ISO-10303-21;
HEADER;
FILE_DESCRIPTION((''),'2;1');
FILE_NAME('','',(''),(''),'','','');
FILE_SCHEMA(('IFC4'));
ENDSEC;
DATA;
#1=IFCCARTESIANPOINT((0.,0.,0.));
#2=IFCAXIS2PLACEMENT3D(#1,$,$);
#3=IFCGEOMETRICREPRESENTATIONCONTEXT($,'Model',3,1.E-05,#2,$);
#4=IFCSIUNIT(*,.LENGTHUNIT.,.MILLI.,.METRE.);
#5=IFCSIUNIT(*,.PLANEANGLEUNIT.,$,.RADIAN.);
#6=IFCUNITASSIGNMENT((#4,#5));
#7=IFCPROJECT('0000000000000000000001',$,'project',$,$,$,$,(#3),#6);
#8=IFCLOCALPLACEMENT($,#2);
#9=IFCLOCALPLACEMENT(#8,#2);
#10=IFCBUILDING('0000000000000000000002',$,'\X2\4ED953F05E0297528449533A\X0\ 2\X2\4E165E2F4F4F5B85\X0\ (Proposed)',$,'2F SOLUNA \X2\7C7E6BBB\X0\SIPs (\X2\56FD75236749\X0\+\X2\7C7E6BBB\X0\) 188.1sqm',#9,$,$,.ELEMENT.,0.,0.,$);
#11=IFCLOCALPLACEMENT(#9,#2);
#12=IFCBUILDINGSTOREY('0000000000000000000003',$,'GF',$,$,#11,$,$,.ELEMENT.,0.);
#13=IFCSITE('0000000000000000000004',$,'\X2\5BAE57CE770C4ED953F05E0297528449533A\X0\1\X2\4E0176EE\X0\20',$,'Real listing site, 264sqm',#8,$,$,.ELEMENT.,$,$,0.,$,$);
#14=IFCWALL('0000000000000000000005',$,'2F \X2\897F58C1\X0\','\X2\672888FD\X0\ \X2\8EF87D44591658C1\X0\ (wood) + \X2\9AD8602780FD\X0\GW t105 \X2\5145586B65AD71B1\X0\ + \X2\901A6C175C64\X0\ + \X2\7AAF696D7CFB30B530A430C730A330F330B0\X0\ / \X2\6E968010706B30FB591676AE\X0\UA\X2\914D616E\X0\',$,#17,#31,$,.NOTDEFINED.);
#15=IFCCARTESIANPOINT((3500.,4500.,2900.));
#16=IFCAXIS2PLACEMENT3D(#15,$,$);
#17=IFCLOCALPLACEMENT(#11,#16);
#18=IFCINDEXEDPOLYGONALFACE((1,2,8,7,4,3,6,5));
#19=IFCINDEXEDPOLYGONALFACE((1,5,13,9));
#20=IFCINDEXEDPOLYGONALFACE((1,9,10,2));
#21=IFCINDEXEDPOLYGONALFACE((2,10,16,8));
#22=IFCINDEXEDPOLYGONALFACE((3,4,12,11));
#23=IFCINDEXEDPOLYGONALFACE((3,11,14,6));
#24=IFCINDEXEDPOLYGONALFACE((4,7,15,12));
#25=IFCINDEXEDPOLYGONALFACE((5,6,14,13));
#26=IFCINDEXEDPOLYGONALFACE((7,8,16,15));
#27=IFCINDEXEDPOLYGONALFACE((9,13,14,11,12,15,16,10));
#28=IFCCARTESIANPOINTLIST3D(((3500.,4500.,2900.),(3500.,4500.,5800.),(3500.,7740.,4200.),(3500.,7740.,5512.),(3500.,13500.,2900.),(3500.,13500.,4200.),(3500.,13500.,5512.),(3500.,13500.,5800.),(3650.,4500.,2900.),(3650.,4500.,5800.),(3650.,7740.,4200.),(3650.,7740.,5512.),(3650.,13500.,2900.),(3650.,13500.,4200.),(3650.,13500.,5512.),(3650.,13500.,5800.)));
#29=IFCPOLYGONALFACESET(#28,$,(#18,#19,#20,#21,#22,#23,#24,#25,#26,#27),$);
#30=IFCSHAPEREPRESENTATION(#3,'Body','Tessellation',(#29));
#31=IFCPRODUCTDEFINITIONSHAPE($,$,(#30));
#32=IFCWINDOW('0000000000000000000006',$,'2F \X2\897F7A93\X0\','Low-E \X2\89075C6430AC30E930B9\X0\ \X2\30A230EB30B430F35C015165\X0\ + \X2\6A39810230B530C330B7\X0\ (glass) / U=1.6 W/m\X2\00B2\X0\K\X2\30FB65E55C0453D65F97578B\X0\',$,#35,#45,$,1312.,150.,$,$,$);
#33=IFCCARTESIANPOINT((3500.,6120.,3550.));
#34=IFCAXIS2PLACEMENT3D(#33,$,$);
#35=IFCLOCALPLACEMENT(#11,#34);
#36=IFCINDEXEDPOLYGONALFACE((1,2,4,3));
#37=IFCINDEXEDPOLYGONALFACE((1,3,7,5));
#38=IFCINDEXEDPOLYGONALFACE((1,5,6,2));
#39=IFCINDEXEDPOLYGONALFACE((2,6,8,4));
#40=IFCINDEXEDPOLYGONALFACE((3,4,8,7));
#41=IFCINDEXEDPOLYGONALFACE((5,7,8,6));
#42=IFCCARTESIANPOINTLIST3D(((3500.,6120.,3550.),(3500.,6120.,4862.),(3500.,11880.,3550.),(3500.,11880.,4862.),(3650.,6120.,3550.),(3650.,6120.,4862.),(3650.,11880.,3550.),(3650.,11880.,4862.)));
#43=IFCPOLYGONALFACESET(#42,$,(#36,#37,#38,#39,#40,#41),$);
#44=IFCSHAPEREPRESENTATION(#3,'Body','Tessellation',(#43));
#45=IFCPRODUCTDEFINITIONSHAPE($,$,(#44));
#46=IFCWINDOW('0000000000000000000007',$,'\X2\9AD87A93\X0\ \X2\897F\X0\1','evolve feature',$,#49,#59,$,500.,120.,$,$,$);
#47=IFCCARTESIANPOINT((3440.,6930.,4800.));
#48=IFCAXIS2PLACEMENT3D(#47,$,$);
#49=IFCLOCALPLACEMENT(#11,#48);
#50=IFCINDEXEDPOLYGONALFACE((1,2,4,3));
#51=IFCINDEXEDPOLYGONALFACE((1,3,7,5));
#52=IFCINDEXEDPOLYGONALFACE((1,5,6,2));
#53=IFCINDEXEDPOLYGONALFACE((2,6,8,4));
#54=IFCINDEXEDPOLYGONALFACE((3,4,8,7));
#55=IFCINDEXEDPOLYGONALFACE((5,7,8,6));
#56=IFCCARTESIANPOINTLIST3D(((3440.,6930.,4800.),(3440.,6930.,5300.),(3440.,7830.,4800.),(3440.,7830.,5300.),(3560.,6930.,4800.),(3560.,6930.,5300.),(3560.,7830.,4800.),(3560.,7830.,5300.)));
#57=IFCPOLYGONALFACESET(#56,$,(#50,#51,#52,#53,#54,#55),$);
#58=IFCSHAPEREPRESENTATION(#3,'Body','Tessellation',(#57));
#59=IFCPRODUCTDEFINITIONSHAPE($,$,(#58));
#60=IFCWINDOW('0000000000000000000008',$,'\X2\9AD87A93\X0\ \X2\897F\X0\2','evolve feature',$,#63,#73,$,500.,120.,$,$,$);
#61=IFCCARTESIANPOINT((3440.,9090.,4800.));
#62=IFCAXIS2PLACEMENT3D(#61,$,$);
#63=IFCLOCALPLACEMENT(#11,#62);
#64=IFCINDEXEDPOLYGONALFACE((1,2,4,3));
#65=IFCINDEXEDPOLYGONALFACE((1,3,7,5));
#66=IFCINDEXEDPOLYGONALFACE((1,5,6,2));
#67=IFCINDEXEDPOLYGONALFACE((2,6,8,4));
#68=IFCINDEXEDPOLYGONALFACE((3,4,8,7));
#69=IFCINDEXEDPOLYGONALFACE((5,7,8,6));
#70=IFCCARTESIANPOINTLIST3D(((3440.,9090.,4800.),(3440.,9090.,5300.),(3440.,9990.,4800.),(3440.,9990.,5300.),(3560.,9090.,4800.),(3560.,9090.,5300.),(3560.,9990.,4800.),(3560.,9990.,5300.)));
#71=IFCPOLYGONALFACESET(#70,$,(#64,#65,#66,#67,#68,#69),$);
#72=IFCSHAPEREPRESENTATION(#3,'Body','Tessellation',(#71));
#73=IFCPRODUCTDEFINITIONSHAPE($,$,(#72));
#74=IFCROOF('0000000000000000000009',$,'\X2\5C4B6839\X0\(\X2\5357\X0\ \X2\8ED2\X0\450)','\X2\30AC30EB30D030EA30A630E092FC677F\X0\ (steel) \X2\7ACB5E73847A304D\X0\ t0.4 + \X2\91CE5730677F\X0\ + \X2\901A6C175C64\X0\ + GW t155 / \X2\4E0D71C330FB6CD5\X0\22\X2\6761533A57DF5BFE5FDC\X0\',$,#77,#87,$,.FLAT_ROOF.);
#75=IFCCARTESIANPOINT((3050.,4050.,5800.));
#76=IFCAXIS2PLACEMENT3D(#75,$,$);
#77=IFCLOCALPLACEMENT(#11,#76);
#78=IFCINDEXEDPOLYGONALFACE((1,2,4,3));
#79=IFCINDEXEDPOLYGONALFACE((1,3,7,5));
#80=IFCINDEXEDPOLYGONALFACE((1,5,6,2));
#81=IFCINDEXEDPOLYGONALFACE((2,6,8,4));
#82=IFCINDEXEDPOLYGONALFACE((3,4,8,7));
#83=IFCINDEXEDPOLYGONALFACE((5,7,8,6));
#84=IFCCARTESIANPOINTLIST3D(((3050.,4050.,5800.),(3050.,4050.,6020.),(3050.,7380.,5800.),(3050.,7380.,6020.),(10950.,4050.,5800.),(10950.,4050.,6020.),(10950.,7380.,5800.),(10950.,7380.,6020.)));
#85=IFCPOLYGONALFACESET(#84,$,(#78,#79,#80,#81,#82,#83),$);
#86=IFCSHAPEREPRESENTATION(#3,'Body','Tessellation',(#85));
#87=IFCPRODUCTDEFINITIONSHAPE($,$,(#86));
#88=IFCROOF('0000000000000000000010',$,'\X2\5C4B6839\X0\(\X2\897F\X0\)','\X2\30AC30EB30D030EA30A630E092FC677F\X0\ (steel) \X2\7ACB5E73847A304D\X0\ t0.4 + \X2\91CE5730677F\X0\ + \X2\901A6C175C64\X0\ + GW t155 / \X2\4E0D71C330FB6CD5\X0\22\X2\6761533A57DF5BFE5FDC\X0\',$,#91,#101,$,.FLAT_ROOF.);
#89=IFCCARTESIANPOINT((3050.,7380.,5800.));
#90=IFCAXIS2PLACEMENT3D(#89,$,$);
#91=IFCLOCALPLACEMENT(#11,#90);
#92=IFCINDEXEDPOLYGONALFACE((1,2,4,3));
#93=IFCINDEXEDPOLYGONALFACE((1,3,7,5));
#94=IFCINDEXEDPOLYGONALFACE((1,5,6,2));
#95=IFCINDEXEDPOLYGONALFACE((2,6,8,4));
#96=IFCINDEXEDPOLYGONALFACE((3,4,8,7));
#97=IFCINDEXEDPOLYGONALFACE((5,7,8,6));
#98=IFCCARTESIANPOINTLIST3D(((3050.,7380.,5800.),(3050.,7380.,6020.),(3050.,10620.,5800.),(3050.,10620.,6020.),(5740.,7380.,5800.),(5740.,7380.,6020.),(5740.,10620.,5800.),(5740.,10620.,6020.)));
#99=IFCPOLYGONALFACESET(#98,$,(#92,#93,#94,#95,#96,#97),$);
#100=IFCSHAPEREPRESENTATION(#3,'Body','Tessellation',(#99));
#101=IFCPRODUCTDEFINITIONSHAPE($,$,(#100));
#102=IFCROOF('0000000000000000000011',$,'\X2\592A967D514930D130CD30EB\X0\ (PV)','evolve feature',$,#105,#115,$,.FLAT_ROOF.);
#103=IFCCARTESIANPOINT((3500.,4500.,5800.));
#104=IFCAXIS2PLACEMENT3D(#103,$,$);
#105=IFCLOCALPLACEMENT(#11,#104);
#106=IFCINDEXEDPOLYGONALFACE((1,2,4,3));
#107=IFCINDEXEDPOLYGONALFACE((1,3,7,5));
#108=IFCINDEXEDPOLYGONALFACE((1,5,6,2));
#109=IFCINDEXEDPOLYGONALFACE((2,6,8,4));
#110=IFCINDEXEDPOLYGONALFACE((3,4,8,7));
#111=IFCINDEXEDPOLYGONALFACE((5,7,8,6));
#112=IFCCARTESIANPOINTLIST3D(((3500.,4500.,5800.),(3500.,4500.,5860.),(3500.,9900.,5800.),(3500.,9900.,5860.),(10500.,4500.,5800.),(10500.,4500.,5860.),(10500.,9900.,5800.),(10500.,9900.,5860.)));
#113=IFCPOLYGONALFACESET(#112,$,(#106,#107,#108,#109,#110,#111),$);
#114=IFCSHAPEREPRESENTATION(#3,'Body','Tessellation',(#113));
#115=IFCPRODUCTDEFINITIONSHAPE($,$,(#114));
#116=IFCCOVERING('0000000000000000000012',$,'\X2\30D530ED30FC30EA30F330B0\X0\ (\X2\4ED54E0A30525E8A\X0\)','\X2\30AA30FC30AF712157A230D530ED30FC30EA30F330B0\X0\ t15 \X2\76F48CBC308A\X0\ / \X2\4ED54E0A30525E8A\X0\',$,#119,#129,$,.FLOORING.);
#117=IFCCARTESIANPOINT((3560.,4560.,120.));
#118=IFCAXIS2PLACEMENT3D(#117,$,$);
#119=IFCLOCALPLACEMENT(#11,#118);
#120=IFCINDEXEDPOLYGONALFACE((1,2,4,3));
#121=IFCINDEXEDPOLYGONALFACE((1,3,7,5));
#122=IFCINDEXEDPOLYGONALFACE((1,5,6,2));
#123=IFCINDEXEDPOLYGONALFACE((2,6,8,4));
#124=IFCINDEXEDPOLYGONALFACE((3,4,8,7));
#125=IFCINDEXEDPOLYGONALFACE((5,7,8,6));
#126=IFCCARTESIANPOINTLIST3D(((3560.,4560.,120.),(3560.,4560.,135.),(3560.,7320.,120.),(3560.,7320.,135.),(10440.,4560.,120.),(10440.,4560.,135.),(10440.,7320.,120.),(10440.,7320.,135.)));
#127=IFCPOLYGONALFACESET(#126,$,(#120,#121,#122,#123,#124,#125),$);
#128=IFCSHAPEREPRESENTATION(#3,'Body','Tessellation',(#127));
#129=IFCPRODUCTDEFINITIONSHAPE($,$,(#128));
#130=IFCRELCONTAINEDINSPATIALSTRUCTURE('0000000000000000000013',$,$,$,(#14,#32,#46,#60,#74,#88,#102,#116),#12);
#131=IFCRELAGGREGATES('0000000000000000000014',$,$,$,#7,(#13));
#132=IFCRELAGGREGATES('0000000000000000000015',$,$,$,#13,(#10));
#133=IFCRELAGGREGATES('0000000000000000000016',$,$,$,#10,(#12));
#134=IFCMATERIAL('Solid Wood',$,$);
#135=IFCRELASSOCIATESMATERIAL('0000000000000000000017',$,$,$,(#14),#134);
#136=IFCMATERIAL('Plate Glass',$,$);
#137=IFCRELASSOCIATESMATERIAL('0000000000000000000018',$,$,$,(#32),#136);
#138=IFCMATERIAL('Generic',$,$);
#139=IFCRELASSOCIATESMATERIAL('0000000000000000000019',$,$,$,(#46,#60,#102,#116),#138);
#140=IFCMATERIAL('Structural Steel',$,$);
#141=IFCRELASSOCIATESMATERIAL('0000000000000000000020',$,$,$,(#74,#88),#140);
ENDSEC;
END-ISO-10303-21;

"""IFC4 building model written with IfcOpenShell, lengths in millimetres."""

from ifc_helpers import new_model, si_unit, frame, frame_2d, origin, place, context, project, spatial, rectangle, extrude, material, element, fill, save


model = new_model("IFC4")

# Units and contexts
model_context = context("Model", 3, precision=1e-05, world=origin())
ifc_project = project(units=[si_unit("LENGTHUNIT", "METRE", prefix="MILLI"), si_unit("PLANEANGLEUNIT", "RADIAN")], contexts=[model_context])

# Site, building, storey
site_placement = place(None, origin())
site = spatial("IfcSite", under=ifc_project, at=site_placement, Name="宮城県仙台市青葉区1丁目20", ObjectType="Real listing site, 264sqm", CompositionType="ELEMENT", RefElevation=0.0)
building_placement = place(site_placement, origin())
building = spatial("IfcBuilding", under=site, at=building_placement, Name="仙台市青葉区 2世帯住宅 (Proposed)", ObjectType="2F SOLUNA 籾殻SIPs (国産杉+籾殻) 188.1sqm", CompositionType="ELEMENT", ElevationOfRefHeight=0.0, ElevationOfTerrain=0.0)
storey_placement = place(building_placement, origin())
storey = spatial("IfcBuildingStorey", under=building, at=storey_placement, Name="GF", CompositionType="ELEMENT", Elevation=0.0)

# Shared definitions
ifc_material_1 = material(Name="Solid Wood")
ifc_material_2 = material(Name="Generic")

# Shared definitions
ifc_material_3 = material(Name="Plate Glass")

# Wall, openings, windows
wall_1_placement = place(storey_placement, frame((3500.0, 4500.0, 2900.0)))
wall_1 = element("IfcWall", 1, at=wall_1_placement, inside=storey, material=ifc_material_1, Name="2F 西壁", Description="木製 軸組外壁 (wood) + 高性能GW t105 充填断熱 + 通気層 + 窯業系サイディング / 準耐火・外皮UA配慮", PredefinedType="NOTDEFINED", context=model_context, shape_type="SweptSolid", body=[
    extrude(rectangle(XDim=150.0, YDim=9000.0, at=frame_2d((75.0, 4500.0))), frame((3500.0, 4500.0, 2900.0)), (0.0, 0.0, 1.0), 2900.0),
])
opening_1_placement = place(storey_placement, frame((3500.0, 6120.0, 3550.0)))
opening_1 = element("IfcOpeningElement", 2, at=opening_1_placement, cuts=wall_1, PredefinedType="NOTDEFINED", context=model_context, shape_type="SweptSolid", body=[
    extrude(rectangle(XDim=150.0, YDim=5760.0, at=frame_2d((75.0, 2880.0))), frame((3500.0, 6120.0, 3550.0)), (0.0, 0.0, 1.0), 1312.0),
])
opening_2_placement = place(storey_placement, frame((3440.0, 6930.0, 4800.0)))
opening_2 = element("IfcOpeningElement", 3, at=opening_2_placement, cuts=wall_1, PredefinedType="NOTDEFINED", context=model_context, shape_type="SweptSolid", body=[
    extrude(rectangle(XDim=120.0, YDim=900.0, at=frame_2d((60.0, 450.0))), frame((3440.0, 6930.0, 4800.0)), (0.0, 0.0, 1.0), 500.0),
])
opening_3_placement = place(storey_placement, frame((3440.0, 9090.0, 4800.0)))
opening_3 = element("IfcOpeningElement", 4, at=opening_3_placement, cuts=wall_1, PredefinedType="NOTDEFINED", context=model_context, shape_type="SweptSolid", body=[
    extrude(rectangle(XDim=120.0, YDim=900.0, at=frame_2d((60.0, 450.0))), frame((3440.0, 9090.0, 4800.0)), (0.0, 0.0, 1.0), 500.0),
])
window_1_placement = place(storey_placement, frame((3500.0, 6120.0, 3550.0)))
window_1 = element("IfcWindow", 5, at=window_1_placement, inside=storey, material=ifc_material_3, Name="2F 西窓", Description="Low-E 複層ガラス アルゴン封入 + 樹脂サッシ (glass) / U=1.6 W/m²K・日射取得型", OverallHeight=1312.0, OverallWidth=150.0, context=model_context, shape_type="SweptSolid", body=[
    extrude(rectangle(XDim=150.0, YDim=5760.0, at=frame_2d((75.0, 2880.0))), frame((3500.0, 6120.0, 3550.0)), (0.0, 0.0, 1.0), 1312.0),
])
fill(opening_1, window_1)
window_2_placement = place(storey_placement, frame((3440.0, 6930.0, 4800.0)))
window_2 = element("IfcWindow", 6, at=window_2_placement, inside=storey, material=ifc_material_2, Name="高窓 西1", Description="evolve feature", OverallHeight=500.0, OverallWidth=120.0, context=model_context, shape_type="SweptSolid", body=[
    extrude(rectangle(XDim=120.0, YDim=900.0, at=frame_2d((60.0, 450.0))), frame((3440.0, 6930.0, 4800.0)), (0.0, 0.0, 1.0), 500.0),
])
fill(opening_2, window_2)
window_3_placement = place(storey_placement, frame((3440.0, 9090.0, 4800.0)))
window_3 = element("IfcWindow", 7, at=window_3_placement, inside=storey, material=ifc_material_2, Name="高窓 西2", Description="evolve feature", OverallHeight=500.0, OverallWidth=120.0, context=model_context, shape_type="SweptSolid", body=[
    extrude(rectangle(XDim=120.0, YDim=900.0, at=frame_2d((60.0, 450.0))), frame((3440.0, 9090.0, 4800.0)), (0.0, 0.0, 1.0), 500.0),
])
fill(opening_3, window_3)

# Roofs
ifc_material_4 = material(Name="Structural Steel")
roof_1_placement = place(storey_placement, frame((3050.0, 4050.0, 5800.0)))
element("IfcRoof", 8, at=roof_1_placement, inside=storey, material=ifc_material_4, Name="屋根(南 軒450)", Description="ガルバリウム鋼板 (steel) 立平葺き t0.4 + 野地板 + 通気層 + GW t155 / 不燃・法22条区域対応", PredefinedType="FLAT_ROOF", context=model_context, shape_type="SweptSolid", body=[
    extrude(rectangle(XDim=7900.0, YDim=3330.0, at=frame_2d((3950.0, 1665.0))), frame((3050.0, 4050.0, 5800.0)), (0.0, 0.0, 1.0), 220.0),
])
roof_2_placement = place(storey_placement, frame((3050.0, 7380.0, 5800.0)))
element("IfcRoof", 9, at=roof_2_placement, inside=storey, material=ifc_material_4, Name="屋根(西)", Description="ガルバリウム鋼板 (steel) 立平葺き t0.4 + 野地板 + 通気層 + GW t155 / 不燃・法22条区域対応", PredefinedType="FLAT_ROOF", context=model_context, shape_type="SweptSolid", body=[
    extrude(rectangle(XDim=2690.0, YDim=3240.0, at=frame_2d((1345.0, 1620.0))), frame((3050.0, 7380.0, 5800.0)), (0.0, 0.0, 1.0), 220.0),
])
roof_3_placement = place(storey_placement, frame((3500.0, 4500.0, 5800.0)))
element("IfcRoof", 10, at=roof_3_placement, inside=storey, material=ifc_material_2, Name="太陽光パネル (PV)", Description="evolve feature", PredefinedType="FLAT_ROOF", context=model_context, shape_type="SweptSolid", body=[
    extrude(rectangle(XDim=7000.0, YDim=5400.0, at=frame_2d((3500.0, 2700.0))), frame((3500.0, 4500.0, 5800.0)), (0.0, 0.0, 1.0), 60.0),
])

# Covering
covering_placement = place(storey_placement, frame((3560.0, 4560.0, 120.0)))
element("IfcCovering", 11, at=covering_placement, inside=storey, material=ifc_material_2, Name="フローリング (仕上げ床)", Description="オーク無垢フローリング t15 直貼り / 仕上げ床", PredefinedType="FLOORING", context=model_context, shape_type="SweptSolid", body=[
    extrude(rectangle(XDim=6880.0, YDim=2760.0, at=frame_2d((3440.0, 1380.0))), frame((3560.0, 4560.0, 120.0)), (0.0, 0.0, 1.0), 15.0),
])

save(model, "model.ifc")
